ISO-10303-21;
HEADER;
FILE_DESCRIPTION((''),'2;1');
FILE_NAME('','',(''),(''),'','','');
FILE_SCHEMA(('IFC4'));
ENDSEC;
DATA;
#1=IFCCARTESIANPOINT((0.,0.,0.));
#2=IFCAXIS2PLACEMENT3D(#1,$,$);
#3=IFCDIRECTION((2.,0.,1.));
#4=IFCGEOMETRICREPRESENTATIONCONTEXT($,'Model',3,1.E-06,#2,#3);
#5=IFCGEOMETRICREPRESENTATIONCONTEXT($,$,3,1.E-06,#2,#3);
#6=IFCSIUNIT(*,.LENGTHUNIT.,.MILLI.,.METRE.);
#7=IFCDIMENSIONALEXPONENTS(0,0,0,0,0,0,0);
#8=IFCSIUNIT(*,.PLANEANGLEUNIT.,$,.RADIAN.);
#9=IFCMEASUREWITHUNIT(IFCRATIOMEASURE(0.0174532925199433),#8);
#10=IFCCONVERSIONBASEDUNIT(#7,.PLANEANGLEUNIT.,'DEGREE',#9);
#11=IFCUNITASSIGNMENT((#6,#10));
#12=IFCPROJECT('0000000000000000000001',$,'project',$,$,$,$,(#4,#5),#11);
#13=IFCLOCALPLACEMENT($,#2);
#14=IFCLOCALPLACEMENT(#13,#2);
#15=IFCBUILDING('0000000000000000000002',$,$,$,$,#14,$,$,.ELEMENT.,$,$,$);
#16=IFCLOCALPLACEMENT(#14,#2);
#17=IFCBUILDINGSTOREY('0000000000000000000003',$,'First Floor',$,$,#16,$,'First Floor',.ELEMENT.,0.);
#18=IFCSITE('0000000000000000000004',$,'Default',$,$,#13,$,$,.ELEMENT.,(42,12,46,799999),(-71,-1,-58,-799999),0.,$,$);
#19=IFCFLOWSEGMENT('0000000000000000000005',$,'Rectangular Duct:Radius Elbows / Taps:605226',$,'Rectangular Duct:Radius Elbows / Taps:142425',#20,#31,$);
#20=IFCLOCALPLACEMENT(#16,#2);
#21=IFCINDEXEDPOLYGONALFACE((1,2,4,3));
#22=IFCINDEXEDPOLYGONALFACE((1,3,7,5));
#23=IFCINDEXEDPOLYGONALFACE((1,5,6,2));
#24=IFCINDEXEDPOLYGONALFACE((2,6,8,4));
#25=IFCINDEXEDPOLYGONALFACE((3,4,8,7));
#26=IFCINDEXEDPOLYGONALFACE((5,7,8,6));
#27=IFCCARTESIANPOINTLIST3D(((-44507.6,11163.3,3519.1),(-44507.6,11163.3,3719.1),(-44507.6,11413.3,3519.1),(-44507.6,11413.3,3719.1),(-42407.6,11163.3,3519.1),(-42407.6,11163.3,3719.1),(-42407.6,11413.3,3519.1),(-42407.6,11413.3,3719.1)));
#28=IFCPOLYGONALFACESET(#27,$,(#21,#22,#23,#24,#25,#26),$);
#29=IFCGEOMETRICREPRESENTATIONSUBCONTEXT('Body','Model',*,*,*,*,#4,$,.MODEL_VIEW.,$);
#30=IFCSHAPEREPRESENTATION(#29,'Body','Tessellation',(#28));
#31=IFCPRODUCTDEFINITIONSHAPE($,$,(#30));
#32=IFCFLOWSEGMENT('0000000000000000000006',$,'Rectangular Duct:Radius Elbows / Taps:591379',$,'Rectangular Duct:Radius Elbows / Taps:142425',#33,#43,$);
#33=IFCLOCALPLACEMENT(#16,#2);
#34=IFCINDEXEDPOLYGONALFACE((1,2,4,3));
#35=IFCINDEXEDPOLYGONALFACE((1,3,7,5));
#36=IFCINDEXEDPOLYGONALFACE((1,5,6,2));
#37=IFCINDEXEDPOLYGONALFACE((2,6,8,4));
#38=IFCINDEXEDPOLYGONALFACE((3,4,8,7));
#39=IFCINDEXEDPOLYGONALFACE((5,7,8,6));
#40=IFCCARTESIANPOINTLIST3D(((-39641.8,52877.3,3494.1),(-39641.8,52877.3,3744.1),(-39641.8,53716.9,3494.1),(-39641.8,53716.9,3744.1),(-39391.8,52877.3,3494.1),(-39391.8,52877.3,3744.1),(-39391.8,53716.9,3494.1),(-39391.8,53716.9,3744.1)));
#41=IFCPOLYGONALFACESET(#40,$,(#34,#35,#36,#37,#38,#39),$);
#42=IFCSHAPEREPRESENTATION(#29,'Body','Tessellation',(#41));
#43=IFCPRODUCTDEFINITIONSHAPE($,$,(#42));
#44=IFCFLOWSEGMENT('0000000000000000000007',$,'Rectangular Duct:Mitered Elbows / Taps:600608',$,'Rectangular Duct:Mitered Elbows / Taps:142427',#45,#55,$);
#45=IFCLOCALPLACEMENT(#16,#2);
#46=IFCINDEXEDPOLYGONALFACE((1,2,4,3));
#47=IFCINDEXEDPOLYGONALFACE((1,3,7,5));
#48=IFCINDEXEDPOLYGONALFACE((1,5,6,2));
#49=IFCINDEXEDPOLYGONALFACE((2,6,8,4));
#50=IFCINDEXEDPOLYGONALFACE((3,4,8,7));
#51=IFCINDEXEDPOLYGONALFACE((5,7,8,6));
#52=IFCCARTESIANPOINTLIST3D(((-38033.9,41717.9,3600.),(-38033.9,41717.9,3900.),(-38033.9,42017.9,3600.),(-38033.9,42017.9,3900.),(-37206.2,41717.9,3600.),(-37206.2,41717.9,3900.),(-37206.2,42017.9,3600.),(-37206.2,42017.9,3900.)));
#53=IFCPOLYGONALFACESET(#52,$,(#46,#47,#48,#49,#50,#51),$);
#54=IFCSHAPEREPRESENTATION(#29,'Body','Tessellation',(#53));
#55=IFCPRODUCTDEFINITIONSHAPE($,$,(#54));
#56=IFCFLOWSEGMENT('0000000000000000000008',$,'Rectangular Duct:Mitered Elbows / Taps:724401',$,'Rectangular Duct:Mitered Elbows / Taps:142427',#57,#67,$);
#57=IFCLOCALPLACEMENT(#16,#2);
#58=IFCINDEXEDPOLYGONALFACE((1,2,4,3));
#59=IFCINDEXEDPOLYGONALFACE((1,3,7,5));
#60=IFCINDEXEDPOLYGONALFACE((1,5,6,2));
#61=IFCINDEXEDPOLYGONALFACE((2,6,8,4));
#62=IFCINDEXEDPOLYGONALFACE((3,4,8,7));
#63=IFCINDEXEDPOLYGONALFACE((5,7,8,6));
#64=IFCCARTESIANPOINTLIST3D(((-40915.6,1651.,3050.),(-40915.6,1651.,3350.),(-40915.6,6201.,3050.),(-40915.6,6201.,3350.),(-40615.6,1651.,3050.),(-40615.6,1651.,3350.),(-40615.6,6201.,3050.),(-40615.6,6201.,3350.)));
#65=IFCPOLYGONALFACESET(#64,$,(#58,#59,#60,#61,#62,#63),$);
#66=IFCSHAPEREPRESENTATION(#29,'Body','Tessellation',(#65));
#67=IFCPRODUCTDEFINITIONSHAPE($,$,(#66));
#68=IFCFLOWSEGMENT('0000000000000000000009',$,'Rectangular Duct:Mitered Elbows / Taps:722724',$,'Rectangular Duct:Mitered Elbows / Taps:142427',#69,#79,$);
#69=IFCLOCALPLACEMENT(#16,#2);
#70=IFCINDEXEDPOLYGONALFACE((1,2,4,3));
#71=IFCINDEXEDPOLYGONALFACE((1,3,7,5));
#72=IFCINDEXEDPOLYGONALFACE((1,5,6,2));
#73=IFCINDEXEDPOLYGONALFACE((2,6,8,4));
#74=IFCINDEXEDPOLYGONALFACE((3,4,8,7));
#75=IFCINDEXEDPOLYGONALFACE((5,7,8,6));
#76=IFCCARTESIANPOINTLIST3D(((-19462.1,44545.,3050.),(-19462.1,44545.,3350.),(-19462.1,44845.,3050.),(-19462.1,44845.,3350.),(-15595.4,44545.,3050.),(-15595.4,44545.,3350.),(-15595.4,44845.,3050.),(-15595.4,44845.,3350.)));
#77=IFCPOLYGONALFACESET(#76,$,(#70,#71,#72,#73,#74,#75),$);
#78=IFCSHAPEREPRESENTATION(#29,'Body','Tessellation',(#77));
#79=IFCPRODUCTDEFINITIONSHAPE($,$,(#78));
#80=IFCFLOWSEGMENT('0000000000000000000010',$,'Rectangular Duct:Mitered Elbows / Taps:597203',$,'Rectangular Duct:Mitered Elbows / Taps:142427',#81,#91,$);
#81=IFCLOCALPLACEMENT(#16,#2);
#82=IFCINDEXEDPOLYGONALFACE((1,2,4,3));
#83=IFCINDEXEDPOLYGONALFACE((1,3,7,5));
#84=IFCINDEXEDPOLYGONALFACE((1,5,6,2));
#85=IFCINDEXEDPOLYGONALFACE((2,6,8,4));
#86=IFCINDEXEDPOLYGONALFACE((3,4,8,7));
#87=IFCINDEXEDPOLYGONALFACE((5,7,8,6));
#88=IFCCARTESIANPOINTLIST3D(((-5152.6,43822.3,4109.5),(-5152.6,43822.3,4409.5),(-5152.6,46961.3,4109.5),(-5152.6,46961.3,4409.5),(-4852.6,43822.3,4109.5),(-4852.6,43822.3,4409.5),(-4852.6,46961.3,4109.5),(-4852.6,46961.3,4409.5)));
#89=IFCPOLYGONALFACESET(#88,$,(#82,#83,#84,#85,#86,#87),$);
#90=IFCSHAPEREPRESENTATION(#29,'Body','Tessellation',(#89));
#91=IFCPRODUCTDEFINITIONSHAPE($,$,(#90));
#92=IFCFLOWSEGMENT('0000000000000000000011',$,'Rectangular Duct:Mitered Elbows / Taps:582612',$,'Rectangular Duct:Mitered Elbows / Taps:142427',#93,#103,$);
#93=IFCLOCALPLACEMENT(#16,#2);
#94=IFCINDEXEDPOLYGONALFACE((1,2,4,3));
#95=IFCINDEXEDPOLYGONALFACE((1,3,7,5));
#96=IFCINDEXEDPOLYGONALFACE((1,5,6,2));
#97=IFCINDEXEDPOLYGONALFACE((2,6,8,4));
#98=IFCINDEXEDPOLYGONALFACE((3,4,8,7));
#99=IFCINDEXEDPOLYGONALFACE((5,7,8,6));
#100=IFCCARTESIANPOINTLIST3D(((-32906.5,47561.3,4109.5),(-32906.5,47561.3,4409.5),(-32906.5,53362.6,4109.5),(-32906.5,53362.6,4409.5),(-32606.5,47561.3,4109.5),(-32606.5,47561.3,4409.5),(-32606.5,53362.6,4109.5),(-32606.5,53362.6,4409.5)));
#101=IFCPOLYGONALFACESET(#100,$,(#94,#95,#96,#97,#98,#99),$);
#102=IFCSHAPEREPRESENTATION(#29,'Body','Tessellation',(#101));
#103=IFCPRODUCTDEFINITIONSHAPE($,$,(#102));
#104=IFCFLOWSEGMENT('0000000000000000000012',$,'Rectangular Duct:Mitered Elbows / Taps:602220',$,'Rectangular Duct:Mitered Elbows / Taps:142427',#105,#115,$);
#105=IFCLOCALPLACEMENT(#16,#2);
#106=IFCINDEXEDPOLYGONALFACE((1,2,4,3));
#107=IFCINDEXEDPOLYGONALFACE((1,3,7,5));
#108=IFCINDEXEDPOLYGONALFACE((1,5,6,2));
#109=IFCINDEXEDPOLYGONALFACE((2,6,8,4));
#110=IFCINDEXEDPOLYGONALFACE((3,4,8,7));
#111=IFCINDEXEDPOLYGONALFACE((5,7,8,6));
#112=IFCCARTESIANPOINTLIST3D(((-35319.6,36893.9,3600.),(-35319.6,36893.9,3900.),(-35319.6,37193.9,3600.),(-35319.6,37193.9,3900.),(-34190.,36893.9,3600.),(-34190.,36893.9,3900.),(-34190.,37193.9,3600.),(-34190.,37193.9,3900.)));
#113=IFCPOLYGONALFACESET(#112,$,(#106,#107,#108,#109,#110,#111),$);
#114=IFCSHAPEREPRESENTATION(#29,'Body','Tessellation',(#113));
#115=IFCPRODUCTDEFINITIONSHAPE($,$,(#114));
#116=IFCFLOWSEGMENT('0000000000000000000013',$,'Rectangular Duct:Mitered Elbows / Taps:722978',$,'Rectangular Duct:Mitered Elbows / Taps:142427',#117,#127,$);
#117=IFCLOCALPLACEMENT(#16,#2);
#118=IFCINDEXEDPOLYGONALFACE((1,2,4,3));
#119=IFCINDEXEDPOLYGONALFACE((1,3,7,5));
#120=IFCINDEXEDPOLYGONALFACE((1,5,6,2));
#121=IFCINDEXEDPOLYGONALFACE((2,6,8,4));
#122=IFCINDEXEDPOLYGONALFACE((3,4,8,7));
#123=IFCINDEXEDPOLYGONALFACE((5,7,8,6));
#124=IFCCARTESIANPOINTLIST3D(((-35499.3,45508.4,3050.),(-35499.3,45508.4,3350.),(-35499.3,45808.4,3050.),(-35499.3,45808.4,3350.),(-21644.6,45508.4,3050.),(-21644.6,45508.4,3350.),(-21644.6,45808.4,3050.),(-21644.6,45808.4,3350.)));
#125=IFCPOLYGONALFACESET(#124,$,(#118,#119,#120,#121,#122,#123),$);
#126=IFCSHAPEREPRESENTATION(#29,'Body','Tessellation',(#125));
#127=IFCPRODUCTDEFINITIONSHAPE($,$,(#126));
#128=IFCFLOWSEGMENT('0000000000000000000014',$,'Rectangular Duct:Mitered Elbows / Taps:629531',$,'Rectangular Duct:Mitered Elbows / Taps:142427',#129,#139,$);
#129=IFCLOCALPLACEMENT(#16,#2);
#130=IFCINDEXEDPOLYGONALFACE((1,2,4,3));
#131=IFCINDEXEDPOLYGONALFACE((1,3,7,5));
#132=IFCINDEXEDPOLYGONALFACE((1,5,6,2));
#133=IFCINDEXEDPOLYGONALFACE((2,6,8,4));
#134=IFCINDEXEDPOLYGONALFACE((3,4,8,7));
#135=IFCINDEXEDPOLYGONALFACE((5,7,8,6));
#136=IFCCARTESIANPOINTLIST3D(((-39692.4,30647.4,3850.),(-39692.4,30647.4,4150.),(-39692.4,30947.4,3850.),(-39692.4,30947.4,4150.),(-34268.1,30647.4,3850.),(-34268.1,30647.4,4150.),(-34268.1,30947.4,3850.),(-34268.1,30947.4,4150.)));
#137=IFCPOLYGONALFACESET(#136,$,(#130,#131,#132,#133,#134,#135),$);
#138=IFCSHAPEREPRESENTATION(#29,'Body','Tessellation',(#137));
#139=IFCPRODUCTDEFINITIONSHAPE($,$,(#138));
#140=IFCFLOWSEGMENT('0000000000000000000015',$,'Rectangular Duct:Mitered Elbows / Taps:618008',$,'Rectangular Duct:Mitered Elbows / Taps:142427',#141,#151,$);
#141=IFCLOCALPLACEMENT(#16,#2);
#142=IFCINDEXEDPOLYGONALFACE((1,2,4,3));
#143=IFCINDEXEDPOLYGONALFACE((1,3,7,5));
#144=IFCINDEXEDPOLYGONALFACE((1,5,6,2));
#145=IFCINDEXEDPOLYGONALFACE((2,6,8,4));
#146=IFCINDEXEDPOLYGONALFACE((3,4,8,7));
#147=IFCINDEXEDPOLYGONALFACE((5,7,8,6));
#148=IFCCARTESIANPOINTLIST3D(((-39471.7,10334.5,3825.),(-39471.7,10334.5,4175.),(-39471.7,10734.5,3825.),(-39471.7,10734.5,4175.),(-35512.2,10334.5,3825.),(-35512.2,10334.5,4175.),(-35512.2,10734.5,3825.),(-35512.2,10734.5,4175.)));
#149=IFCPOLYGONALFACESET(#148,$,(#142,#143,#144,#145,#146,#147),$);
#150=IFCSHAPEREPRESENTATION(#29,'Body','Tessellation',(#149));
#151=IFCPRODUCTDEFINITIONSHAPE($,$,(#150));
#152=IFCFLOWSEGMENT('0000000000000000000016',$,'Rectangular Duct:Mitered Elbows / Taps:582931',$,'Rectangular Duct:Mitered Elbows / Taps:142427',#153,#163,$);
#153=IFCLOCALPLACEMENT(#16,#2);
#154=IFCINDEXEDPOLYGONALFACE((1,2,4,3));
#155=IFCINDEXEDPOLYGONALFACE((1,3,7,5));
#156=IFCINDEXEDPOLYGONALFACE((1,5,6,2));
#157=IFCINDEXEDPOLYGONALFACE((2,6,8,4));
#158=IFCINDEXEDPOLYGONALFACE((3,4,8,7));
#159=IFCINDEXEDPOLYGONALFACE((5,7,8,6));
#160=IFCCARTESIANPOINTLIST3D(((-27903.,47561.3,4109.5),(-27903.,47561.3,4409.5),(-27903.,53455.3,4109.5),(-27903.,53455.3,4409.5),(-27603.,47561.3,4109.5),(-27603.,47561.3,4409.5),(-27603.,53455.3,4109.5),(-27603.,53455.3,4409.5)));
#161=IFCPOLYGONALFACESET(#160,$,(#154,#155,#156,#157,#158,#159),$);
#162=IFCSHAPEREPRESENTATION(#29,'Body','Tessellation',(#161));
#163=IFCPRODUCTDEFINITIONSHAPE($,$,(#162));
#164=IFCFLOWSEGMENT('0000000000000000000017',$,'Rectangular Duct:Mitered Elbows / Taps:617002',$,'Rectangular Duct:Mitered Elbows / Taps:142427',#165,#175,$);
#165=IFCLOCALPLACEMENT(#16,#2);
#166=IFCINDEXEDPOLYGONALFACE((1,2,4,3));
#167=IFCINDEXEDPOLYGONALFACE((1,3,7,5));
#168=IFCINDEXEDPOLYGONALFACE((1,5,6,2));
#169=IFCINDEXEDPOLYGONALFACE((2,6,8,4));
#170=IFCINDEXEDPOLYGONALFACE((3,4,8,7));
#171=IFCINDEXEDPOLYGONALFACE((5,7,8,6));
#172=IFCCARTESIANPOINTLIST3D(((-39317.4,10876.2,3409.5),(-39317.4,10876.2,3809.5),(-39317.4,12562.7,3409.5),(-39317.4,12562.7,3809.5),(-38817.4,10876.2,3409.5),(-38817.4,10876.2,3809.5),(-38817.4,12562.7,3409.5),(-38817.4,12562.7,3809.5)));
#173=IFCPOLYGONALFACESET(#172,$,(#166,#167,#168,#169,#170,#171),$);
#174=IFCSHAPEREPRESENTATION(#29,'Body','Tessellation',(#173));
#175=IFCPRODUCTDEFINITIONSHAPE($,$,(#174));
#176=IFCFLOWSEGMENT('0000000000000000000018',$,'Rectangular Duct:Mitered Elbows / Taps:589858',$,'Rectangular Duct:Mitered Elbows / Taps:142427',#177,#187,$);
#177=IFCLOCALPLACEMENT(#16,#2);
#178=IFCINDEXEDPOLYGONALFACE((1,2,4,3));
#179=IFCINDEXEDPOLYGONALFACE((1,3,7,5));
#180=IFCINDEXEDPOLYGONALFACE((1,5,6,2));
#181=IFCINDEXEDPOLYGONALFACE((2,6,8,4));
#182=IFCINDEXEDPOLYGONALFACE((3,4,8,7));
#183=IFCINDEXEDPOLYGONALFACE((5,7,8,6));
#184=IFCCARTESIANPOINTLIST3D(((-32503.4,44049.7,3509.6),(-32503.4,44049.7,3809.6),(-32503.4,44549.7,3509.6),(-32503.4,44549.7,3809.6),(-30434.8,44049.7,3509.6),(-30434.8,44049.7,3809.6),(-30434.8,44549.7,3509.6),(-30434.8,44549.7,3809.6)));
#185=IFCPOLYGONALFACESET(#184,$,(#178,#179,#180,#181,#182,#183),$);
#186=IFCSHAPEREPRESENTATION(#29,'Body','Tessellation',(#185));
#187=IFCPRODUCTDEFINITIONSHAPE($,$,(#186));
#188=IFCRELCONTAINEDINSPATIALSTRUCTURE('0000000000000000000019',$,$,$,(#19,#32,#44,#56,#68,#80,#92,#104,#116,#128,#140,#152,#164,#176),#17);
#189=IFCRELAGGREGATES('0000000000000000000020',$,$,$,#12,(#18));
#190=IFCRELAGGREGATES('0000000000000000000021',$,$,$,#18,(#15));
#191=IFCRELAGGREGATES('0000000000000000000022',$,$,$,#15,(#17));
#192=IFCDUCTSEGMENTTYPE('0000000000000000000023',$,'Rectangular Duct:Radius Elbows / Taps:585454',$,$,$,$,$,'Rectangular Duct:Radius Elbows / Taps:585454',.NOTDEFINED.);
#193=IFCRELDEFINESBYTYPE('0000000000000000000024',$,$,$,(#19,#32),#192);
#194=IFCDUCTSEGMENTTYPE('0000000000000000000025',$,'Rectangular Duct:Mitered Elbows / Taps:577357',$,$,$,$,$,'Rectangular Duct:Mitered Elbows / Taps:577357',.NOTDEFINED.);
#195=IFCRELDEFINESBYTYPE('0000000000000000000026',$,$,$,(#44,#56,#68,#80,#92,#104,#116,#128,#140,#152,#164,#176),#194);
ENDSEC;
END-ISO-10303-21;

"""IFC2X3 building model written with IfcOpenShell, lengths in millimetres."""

from ifc_helpers import new_model, entity, si_unit, converted_unit, direction, frame, frame_2d, origin, origin_2d_with_axis, place, context, subcontext, project, spatial, rectangle, extrude, type_object, element, save


model = new_model("IFC2X3")

# Units and contexts
model_context = context("Model", 3, precision=1e-06, world=origin(), true_north=direction((2.0, 0.0, 1.0)))
context_of_model = context(None, 3, precision=1e-06, world=origin(), true_north=direction((2.0, 0.0, 1.0)))
body_context = subcontext(model_context, "Body", "Model", "MODEL_VIEW")
ifc_project = project(units=[si_unit("LENGTHUNIT", "METRE", prefix="MILLI"), converted_unit("PLANEANGLEUNIT", "DEGREE", entity("IfcRatioMeasure", 0.0174532925199433), si_unit("PLANEANGLEUNIT", "RADIAN"), dimensions=[0, 0, 0, 0, 0, 0, 0])], contexts=[model_context, context_of_model])

# Site, building, storey
site_placement = place(None, origin())
site = spatial("IfcSite", under=ifc_project, at=site_placement, Name="Default", CompositionType="ELEMENT", RefLatitude=(42, 12, 46, 799999), RefLongitude=(-71, -1, -58, -799999), RefElevation=0.0)
building_placement = place(site_placement, origin())
building = spatial("IfcBuilding", under=site, at=building_placement, CompositionType="ELEMENT")
storey_placement = place(building_placement, origin())
storey = spatial("IfcBuildingStorey", under=building, at=storey_placement, Name="First Floor", LongName="First Floor", CompositionType="ELEMENT", Elevation=0.0)

# Flow segments
duct_segment_type_1 = type_object("IfcDuctSegmentType", Name="Rectangular Duct:Radius Elbows / Taps:585454", ElementType="Rectangular Duct:Radius Elbows / Taps:585454", PredefinedType="NOTDEFINED")
flow_segment_1_placement = place(storey_placement, origin())
element("IfcFlowSegment", 1, at=flow_segment_1_placement, inside=storey, type_object=duct_segment_type_1, Name="Rectangular Duct:Radius Elbows / Taps:605226", ObjectType="Rectangular Duct:Radius Elbows / Taps:142425", context=body_context, shape_type="SweptSolid", body=[
    extrude(rectangle(XDim=2100.0, YDim=250.0, at=frame_2d((0.0, 0.0), x_axis=(1.0, 0.0))), frame((-43457.6, 11288.3, 3519.1)), (0.0, 0.0, 1.0), 200.0),
])
flow_segment_2_placement = place(storey_placement, origin())
element("IfcFlowSegment", 2, at=flow_segment_2_placement, inside=storey, type_object=duct_segment_type_1, Name="Rectangular Duct:Radius Elbows / Taps:591379", ObjectType="Rectangular Duct:Radius Elbows / Taps:142425", context=body_context, shape_type="SweptSolid", body=[
    extrude(rectangle(XDim=839.6, YDim=250.0, at=frame_2d((0.0, 0.0), x_axis=(1.0, 0.0))), frame((-39516.8, 53297.1, 3494.1), z_axis=(0.0, 0.0, 1.0), x_axis=(0.0, 1.0, 0.0)), (0.0, 0.0, 1.0), 250.0),
])
duct_segment_type_2 = type_object("IfcDuctSegmentType", Name="Rectangular Duct:Mitered Elbows / Taps:577357", ElementType="Rectangular Duct:Mitered Elbows / Taps:577357", PredefinedType="NOTDEFINED")
flow_segment_3_placement = place(storey_placement, origin())
element("IfcFlowSegment", 3, at=flow_segment_3_placement, inside=storey, type_object=duct_segment_type_2, Name="Rectangular Duct:Mitered Elbows / Taps:600608", ObjectType="Rectangular Duct:Mitered Elbows / Taps:142427", context=body_context, shape_type="SweptSolid", body=[
    extrude(rectangle(XDim=827.7, YDim=300.0, at=origin_2d_with_axis()), frame((-37620.0, 41867.9, 3600.0), z_axis=(0.0, 0.0, 1.0), x_axis=(-1.0, 0.0, 0.0)), (0.0, 0.0, 1.0), 300.0),
])
flow_segment_4_placement = place(storey_placement, origin())
element("IfcFlowSegment", 4, at=flow_segment_4_placement, inside=storey, type_object=duct_segment_type_2, Name="Rectangular Duct:Mitered Elbows / Taps:724401", ObjectType="Rectangular Duct:Mitered Elbows / Taps:142427", context=body_context, shape_type="SweptSolid", body=[
    extrude(rectangle(XDim=4550.0, YDim=300.0, at=origin_2d_with_axis()), frame((-40765.6, 3926.0, 3050.0), z_axis=(0.0, 0.0, 1.0), x_axis=(0.0, 1.0, 0.0)), (0.0, 0.0, 1.0), 300.0),
])
flow_segment_5_placement = place(storey_placement, origin())
element("IfcFlowSegment", 5, at=flow_segment_5_placement, inside=storey, type_object=duct_segment_type_2, Name="Rectangular Duct:Mitered Elbows / Taps:722724", ObjectType="Rectangular Duct:Mitered Elbows / Taps:142427", context=body_context, shape_type="SweptSolid", body=[
    extrude(rectangle(XDim=3866.7, YDim=300.0, at=frame_2d((0.0, 0.0), x_axis=(1.0, 0.0))), frame((-17528.7, 44695.0, 3050.0), z_axis=(0.0, 0.0, 1.0), x_axis=(-1.0, 0.0, 0.0)), (0.0, 0.0, 1.0), 300.0),
])
flow_segment_6_placement = place(storey_placement, origin())
element("IfcFlowSegment", 6, at=flow_segment_6_placement, inside=storey, type_object=duct_segment_type_2, Name="Rectangular Duct:Mitered Elbows / Taps:597203", ObjectType="Rectangular Duct:Mitered Elbows / Taps:142427", context=body_context, shape_type="SweptSolid", body=[
    extrude(rectangle(XDim=3139.0, YDim=300.0, at=frame_2d((0.0, 0.0), x_axis=(1.0, 0.0))), frame((-5002.6, 45391.8, 4109.5), z_axis=(0.0, 0.0, 1.0), x_axis=(0.0, 1.0, 0.0)), (0.0, 0.0, 1.0), 300.0),
])
flow_segment_7_placement = place(storey_placement, origin())
element("IfcFlowSegment", 7, at=flow_segment_7_placement, inside=storey, type_object=duct_segment_type_2, Name="Rectangular Duct:Mitered Elbows / Taps:582612", ObjectType="Rectangular Duct:Mitered Elbows / Taps:142427", context=body_context, shape_type="SweptSolid", body=[
    extrude(rectangle(XDim=5801.3, YDim=300.0, at=origin_2d_with_axis()), frame((-32756.5, 50462.0, 4109.5), z_axis=(0.0, 0.0, 1.0), x_axis=(0.0, -1.0, 0.0)), (0.0, 0.0, 1.0), 300.0),
])
flow_segment_8_placement = place(storey_placement, origin())
element("IfcFlowSegment", 8, at=flow_segment_8_placement, inside=storey, type_object=duct_segment_type_2, Name="Rectangular Duct:Mitered Elbows / Taps:602220", ObjectType="Rectangular Duct:Mitered Elbows / Taps:142427", context=body_context, shape_type="SweptSolid", body=[
    extrude(rectangle(XDim=1129.6, YDim=300.0, at=frame_2d((0.0, 0.0), x_axis=(1.0, 0.0))), frame((-34754.8, 37043.9, 3600.0), z_axis=(0.0, 0.0, 1.0), x_axis=(-1.0, 0.0, 0.0)), (0.0, 0.0, 1.0), 300.0),
])
flow_segment_9_placement = place(storey_placement, origin())
element("IfcFlowSegment", 9, at=flow_segment_9_placement, inside=storey, type_object=duct_segment_type_2, Name="Rectangular Duct:Mitered Elbows / Taps:722978", ObjectType="Rectangular Duct:Mitered Elbows / Taps:142427", context=body_context, shape_type="SweptSolid", body=[
    extrude(rectangle(XDim=13854.6, YDim=300.0, at=origin_2d_with_axis()), frame((-28572.0, 45658.4, 3050.0), z_axis=(0.0, 0.0, 1.0), x_axis=(-1.0, 0.0, 0.0)), (0.0, 0.0, 1.0), 300.0),
])
flow_segment_10_placement = place(storey_placement, origin())
element("IfcFlowSegment", 10, at=flow_segment_10_placement, inside=storey, type_object=duct_segment_type_2, Name="Rectangular Duct:Mitered Elbows / Taps:629531", ObjectType="Rectangular Duct:Mitered Elbows / Taps:142427", context=body_context, shape_type="SweptSolid", body=[
    extrude(rectangle(XDim=5424.3, YDim=300.0, at=origin_2d_with_axis()), frame((-36980.2, 30797.4, 3850.0), z_axis=(0.0, 0.0, 1.0), x_axis=(-1.0, 0.0, 0.0)), (0.0, 0.0, 1.0), 300.0),
])
flow_segment_11_placement = place(storey_placement, origin())
element("IfcFlowSegment", 11, at=flow_segment_11_placement, inside=storey, type_object=duct_segment_type_2, Name="Rectangular Duct:Mitered Elbows / Taps:618008", ObjectType="Rectangular Duct:Mitered Elbows / Taps:142427", context=body_context, shape_type="SweptSolid", body=[
    extrude(rectangle(XDim=3959.5, YDim=400.0, at=frame_2d((0.0, 0.0), x_axis=(1.0, 0.0))), frame((-37491.9, 10534.5, 3825.0)), (0.0, 0.0, 1.0), 350.0),
])
flow_segment_12_placement = place(storey_placement, origin())
element("IfcFlowSegment", 12, at=flow_segment_12_placement, inside=storey, type_object=duct_segment_type_2, Name="Rectangular Duct:Mitered Elbows / Taps:582931", ObjectType="Rectangular Duct:Mitered Elbows / Taps:142427", context=body_context, shape_type="SweptSolid", body=[
    extrude(rectangle(XDim=5894.0, YDim=300.0, at=origin_2d_with_axis()), frame((-27753.0, 50508.3, 4109.5), z_axis=(0.0, 0.0, 1.0), x_axis=(0.0, -1.0, 0.0)), (0.0, 0.0, 1.0), 300.0),
])
flow_segment_13_placement = place(storey_placement, origin())
element("IfcFlowSegment", 13, at=flow_segment_13_placement, inside=storey, type_object=duct_segment_type_2, Name="Rectangular Duct:Mitered Elbows / Taps:617002", ObjectType="Rectangular Duct:Mitered Elbows / Taps:142427", context=body_context, shape_type="SweptSolid", body=[
    extrude(rectangle(XDim=1686.4, YDim=500.0, at=frame_2d((0.0, 0.0), x_axis=(1.0, 0.0))), frame((-39067.4, 11719.4, 3409.5), z_axis=(0.0, 0.0, 1.0), x_axis=(0.0, 1.0, 0.0)), (0.0, 0.0, 1.0), 400.0),
])
flow_segment_14_placement = place(storey_placement, origin())
element("IfcFlowSegment", 14, at=flow_segment_14_placement, inside=storey, type_object=duct_segment_type_2, Name="Rectangular Duct:Mitered Elbows / Taps:589858", ObjectType="Rectangular Duct:Mitered Elbows / Taps:142427", context=body_context, shape_type="SweptSolid", body=[
    extrude(rectangle(XDim=2068.6, YDim=500.0, at=frame_2d((0.0, 0.0), x_axis=(1.0, 0.0))), frame((-31469.1, 44299.7, 3509.6), z_axis=(0.0, 0.0, 1.0), x_axis=(-1.0, 0.0, 0.0)), (0.0, 0.0, 1.0), 300.0),
])

save(model, "model.ifc")
